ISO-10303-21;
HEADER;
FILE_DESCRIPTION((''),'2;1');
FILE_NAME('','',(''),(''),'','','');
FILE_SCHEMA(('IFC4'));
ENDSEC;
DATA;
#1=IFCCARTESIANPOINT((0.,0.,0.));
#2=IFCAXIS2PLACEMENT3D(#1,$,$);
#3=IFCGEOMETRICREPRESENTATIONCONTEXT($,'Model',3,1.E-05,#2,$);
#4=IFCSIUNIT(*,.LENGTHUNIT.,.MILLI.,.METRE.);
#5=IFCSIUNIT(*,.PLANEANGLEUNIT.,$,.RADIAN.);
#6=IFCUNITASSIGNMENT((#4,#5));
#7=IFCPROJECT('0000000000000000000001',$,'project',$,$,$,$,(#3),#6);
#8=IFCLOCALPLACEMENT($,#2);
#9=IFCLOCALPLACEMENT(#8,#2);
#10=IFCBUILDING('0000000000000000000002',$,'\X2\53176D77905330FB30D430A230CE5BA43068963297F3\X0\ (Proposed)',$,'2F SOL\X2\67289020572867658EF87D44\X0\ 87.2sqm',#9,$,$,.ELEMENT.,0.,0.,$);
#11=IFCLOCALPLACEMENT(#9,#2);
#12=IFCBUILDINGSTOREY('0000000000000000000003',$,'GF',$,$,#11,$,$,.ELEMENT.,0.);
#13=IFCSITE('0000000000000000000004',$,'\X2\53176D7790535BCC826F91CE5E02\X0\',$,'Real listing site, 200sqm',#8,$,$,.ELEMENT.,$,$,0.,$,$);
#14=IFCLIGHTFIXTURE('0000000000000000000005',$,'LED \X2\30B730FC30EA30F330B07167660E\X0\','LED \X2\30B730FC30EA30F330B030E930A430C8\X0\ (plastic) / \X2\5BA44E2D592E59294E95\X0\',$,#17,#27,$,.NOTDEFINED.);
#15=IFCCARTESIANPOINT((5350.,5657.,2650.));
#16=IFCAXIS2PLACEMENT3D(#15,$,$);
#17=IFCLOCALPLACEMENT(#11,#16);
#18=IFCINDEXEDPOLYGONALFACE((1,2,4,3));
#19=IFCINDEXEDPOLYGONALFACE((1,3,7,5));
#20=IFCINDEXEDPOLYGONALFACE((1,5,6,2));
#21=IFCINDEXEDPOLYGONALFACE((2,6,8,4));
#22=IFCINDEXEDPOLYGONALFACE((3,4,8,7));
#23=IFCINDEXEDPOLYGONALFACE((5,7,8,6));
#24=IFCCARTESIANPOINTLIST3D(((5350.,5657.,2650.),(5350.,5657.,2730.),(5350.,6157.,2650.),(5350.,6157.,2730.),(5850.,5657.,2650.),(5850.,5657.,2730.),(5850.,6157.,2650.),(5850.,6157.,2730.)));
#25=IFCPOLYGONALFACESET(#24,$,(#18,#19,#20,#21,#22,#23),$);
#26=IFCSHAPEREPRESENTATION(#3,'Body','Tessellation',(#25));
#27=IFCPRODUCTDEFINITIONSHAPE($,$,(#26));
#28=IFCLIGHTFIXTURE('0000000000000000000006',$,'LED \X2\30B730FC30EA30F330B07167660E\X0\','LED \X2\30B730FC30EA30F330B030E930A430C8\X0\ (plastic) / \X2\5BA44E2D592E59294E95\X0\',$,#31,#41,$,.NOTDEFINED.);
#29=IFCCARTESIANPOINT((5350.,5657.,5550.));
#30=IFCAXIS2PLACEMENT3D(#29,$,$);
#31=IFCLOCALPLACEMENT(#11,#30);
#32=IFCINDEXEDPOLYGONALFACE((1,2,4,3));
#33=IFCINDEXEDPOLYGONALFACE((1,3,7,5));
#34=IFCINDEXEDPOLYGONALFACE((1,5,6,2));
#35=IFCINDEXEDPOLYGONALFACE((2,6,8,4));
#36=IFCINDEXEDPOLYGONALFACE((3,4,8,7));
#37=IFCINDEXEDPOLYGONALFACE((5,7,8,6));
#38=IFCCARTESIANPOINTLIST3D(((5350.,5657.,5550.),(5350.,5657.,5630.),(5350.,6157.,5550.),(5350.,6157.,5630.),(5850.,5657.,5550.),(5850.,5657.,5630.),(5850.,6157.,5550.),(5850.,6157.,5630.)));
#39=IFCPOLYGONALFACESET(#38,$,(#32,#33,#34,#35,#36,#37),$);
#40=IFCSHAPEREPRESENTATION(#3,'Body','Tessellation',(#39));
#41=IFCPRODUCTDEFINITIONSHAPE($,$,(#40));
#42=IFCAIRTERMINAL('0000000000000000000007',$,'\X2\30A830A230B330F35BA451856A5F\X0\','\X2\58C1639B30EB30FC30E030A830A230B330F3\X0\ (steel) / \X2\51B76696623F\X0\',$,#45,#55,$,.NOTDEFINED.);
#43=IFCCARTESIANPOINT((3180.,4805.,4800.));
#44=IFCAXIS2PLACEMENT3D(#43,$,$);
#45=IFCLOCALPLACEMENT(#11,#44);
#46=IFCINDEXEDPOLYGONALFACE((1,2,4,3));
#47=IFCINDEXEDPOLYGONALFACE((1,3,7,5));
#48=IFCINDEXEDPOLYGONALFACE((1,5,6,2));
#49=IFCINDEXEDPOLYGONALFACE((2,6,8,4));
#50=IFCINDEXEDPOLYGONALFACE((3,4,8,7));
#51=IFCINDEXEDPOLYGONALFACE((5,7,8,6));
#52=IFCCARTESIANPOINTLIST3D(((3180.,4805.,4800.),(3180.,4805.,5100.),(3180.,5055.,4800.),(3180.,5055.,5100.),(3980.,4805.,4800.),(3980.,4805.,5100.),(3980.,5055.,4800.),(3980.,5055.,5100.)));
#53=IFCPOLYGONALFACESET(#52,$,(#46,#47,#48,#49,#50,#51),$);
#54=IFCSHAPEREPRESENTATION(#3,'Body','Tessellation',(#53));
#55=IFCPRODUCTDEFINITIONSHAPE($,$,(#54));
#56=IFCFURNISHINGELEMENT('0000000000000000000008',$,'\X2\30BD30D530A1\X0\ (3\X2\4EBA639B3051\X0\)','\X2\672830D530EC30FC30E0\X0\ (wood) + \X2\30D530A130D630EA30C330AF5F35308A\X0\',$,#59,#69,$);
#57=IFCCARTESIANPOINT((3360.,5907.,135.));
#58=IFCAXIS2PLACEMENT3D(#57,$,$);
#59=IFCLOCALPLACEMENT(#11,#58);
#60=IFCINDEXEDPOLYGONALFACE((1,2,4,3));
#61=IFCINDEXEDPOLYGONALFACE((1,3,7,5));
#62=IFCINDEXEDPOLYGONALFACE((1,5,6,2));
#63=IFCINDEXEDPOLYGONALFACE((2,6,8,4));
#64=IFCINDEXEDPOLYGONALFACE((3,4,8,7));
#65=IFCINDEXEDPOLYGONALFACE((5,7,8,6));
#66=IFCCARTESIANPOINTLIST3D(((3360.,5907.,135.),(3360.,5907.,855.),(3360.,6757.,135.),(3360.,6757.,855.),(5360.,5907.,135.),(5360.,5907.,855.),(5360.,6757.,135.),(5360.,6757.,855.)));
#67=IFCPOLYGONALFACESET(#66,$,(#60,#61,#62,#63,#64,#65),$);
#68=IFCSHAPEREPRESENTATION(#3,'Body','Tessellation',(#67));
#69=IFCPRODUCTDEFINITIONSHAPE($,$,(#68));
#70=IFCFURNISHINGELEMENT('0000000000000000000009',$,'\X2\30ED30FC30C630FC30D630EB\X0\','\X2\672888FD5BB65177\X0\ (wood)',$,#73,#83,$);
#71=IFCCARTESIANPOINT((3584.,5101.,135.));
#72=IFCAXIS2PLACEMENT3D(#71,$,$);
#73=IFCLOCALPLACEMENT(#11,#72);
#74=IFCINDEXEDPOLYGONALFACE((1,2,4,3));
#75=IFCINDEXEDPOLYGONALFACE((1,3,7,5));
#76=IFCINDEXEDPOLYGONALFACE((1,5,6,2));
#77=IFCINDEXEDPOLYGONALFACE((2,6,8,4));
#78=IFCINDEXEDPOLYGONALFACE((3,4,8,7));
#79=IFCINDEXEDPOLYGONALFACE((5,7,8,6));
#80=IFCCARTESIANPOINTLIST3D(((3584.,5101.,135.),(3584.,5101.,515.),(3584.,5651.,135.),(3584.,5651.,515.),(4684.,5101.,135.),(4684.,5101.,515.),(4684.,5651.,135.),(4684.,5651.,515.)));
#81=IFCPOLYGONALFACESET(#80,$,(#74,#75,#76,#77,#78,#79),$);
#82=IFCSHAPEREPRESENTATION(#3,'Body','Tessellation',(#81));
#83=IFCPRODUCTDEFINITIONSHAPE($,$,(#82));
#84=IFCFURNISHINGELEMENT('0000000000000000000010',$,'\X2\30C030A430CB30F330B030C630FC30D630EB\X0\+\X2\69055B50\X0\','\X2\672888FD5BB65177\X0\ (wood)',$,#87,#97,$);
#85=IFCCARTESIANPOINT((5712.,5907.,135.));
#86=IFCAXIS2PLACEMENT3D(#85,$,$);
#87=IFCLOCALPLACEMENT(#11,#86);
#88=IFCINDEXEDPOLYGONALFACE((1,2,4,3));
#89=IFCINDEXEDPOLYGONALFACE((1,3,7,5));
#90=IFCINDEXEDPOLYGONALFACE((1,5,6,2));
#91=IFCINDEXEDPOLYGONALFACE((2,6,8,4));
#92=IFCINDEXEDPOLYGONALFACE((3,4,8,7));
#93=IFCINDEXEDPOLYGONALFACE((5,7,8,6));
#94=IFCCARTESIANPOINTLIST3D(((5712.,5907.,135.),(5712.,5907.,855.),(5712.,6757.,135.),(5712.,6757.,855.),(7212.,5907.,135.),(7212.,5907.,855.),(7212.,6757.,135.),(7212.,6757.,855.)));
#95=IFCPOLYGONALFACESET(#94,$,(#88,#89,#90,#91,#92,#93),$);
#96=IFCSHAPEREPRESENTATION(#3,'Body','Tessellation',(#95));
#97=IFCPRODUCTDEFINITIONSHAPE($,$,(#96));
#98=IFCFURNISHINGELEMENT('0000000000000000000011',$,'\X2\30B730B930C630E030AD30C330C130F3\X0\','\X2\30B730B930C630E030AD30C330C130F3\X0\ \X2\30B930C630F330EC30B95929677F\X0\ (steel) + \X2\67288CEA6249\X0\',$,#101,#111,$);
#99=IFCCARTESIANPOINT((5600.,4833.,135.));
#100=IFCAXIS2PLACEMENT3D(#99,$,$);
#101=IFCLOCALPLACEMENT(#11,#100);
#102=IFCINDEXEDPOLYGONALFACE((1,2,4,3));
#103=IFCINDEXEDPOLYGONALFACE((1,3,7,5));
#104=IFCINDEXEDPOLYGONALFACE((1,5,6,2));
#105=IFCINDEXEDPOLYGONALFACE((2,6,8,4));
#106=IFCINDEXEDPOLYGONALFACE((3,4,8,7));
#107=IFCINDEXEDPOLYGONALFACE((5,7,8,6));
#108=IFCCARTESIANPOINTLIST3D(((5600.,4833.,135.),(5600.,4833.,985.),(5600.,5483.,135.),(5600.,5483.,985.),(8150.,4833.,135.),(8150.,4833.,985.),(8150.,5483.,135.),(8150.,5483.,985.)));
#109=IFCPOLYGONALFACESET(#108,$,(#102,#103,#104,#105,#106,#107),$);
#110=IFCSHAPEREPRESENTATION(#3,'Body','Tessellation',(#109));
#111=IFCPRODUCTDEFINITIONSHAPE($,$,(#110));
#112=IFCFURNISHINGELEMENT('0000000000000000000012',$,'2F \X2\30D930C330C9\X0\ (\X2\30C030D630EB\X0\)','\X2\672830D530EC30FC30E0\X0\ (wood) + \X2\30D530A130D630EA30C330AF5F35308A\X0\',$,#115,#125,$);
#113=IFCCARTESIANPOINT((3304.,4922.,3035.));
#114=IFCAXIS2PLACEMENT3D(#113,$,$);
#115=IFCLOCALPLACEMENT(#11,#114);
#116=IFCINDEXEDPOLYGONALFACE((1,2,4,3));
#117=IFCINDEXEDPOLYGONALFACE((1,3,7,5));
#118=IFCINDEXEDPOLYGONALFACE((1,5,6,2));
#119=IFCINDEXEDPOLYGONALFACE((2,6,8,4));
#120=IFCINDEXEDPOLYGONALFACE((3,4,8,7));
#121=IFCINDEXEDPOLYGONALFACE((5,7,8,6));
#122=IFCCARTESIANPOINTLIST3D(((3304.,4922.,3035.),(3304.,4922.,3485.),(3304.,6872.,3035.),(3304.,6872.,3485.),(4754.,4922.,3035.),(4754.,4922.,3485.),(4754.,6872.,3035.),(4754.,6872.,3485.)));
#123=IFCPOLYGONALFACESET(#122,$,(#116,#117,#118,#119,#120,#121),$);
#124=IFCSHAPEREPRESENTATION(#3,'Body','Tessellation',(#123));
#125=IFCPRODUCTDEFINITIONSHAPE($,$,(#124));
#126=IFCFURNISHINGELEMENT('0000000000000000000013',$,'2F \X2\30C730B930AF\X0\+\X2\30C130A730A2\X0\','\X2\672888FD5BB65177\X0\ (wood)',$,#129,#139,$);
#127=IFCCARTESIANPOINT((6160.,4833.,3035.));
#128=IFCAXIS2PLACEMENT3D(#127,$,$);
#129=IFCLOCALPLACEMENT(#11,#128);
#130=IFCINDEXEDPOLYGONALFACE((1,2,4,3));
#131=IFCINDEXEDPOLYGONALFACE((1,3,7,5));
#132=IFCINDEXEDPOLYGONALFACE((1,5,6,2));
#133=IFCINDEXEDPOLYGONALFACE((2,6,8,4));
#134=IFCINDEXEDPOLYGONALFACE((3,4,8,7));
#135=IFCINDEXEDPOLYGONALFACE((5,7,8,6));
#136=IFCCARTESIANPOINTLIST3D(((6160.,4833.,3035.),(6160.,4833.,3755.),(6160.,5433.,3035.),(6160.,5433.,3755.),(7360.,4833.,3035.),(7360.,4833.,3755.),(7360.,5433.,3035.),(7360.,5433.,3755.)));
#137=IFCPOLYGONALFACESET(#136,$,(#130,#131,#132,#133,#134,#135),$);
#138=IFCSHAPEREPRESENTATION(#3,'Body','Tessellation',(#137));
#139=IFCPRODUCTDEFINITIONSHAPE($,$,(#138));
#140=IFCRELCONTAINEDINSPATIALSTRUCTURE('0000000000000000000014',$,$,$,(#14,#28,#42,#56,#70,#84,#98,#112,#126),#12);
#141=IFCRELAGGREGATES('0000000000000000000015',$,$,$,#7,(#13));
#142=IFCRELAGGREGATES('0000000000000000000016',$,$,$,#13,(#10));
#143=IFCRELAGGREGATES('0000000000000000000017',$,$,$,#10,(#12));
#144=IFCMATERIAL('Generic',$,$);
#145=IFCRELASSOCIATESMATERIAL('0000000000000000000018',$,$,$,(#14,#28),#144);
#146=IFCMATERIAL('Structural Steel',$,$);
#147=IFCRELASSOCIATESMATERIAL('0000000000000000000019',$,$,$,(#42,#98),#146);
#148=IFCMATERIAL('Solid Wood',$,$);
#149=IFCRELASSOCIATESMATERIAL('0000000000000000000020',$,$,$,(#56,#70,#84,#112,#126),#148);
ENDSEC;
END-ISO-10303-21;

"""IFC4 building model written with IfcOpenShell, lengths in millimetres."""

from ifc_helpers import new_model, si_unit, frame, frame_2d, origin, place, context, project, spatial, rectangle, extrude, material, element, save


model = new_model("IFC4")

# Units and contexts
model_context = context("Model", 3, precision=1e-05, world=origin())
ifc_project = project(units=[si_unit("LENGTHUNIT", "METRE", prefix="MILLI"), si_unit("PLANEANGLEUNIT", "RADIAN")], contexts=[model_context])

# Site, building, storey
site_placement = place(None, origin())
site = spatial("IfcSite", under=ifc_project, at=site_placement, Name="北海道富良野市", ObjectType="Real listing site, 200sqm", CompositionType="ELEMENT", RefElevation=0.0)
building_placement = place(site_placement, origin())
building = spatial("IfcBuilding", under=site, at=building_placement, Name="北海道・ピアノ室と防音 (Proposed)", ObjectType="2F SOL木造在来軸組 87.2sqm", CompositionType="ELEMENT", ElevationOfRefHeight=0.0, ElevationOfTerrain=0.0)
storey_placement = place(building_placement, origin())
storey = spatial("IfcBuildingStorey", under=building, at=storey_placement, Name="GF", CompositionType="ELEMENT", Elevation=0.0)

# Shared definitions
ifc_material_1 = material(Name="Solid Wood")

# Shared definitions
ifc_material_2 = material(Name="Generic")

# Shared definitions
ifc_material_3 = material(Name="Structural Steel")

# Light fixtures
light_fixture_1_placement = place(storey_placement, frame((5350.0, 5657.0, 2650.0)))
element("IfcLightFixture", 1, at=light_fixture_1_placement, inside=storey, material=ifc_material_2, Name="LED シーリング照明", Description="LED シーリングライト (plastic) / 室中央天井", PredefinedType="NOTDEFINED", context=model_context, shape_type="SweptSolid", body=[
    extrude(rectangle(XDim=500.0, YDim=500.0, at=frame_2d((250.0, 250.0))), frame((5350.0, 5657.0, 2650.0)), (0.0, 0.0, 1.0), 80.0),
])
light_fixture_2_placement = place(storey_placement, frame((5350.0, 5657.0, 5550.0)))
element("IfcLightFixture", 2, at=light_fixture_2_placement, inside=storey, material=ifc_material_2, Name="LED シーリング照明", Description="LED シーリングライト (plastic) / 室中央天井", PredefinedType="NOTDEFINED", context=model_context, shape_type="SweptSolid", body=[
    extrude(rectangle(XDim=500.0, YDim=500.0, at=frame_2d((250.0, 250.0))), frame((5350.0, 5657.0, 5550.0)), (0.0, 0.0, 1.0), 80.0),
])

# Air terminal
air_terminal_placement = place(storey_placement, frame((3180.0, 4805.0, 4800.0)))
element("IfcAirTerminal", 3, at=air_terminal_placement, inside=storey, material=ifc_material_3, Name="エアコン室内機", Description="壁掛ルームエアコン (steel) / 冷暖房", PredefinedType="NOTDEFINED", context=model_context, shape_type="SweptSolid", body=[
    extrude(rectangle(XDim=800.0, YDim=250.0, at=frame_2d((400.0, 125.0))), frame((3180.0, 4805.0, 4800.0)), (0.0, 0.0, 1.0), 300.0),
])

# Furnishing elements
furnishing_1_placement = place(storey_placement, frame((3360.0, 5907.0, 135.0)))
element("IfcFurnishingElement", 4, at=furnishing_1_placement, inside=storey, material=ifc_material_1, Name="ソファ (3人掛け)", Description="木フレーム (wood) + ファブリック張り", context=model_context, shape_type="SweptSolid", body=[
    extrude(rectangle(XDim=2000.0, YDim=850.0, at=frame_2d((1000.0, 425.0))), frame((3360.0, 5907.0, 135.0)), (0.0, 0.0, 1.0), 720.0),
])
furnishing_2_placement = place(storey_placement, frame((3584.0, 5101.0, 135.0)))
element("IfcFurnishingElement", 5, at=furnishing_2_placement, inside=storey, material=ifc_material_1, Name="ローテーブル", Description="木製家具 (wood)", context=model_context, shape_type="SweptSolid", body=[
    extrude(rectangle(XDim=1100.0, YDim=550.0, at=frame_2d((550.0, 275.0))), frame((3584.0, 5101.0, 135.0)), (0.0, 0.0, 1.0), 380.0),
])
furnishing_3_placement = place(storey_placement, frame((5712.0, 5907.0, 135.0)))
element("IfcFurnishingElement", 6, at=furnishing_3_placement, inside=storey, material=ifc_material_1, Name="ダイニングテーブル+椅子", Description="木製家具 (wood)", context=model_context, shape_type="SweptSolid", body=[
    extrude(rectangle(XDim=1500.0, YDim=850.0, at=frame_2d((750.0, 425.0))), frame((5712.0, 5907.0, 135.0)), (0.0, 0.0, 1.0), 720.0),
])
furnishing_4_placement = place(storey_placement, frame((5600.0, 4833.0, 135.0)))
element("IfcFurnishingElement", 7, at=furnishing_4_placement, inside=storey, material=ifc_material_3, Name="システムキッチン", Description="システムキッチン ステンレス天板 (steel) + 木質扉", context=model_context, shape_type="SweptSolid", body=[
    extrude(rectangle(XDim=2550.0, YDim=650.0, at=frame_2d((1275.0, 325.0))), frame((5600.0, 4833.0, 135.0)), (0.0, 0.0, 1.0), 850.0),
])
furnishing_5_placement = place(storey_placement, frame((3304.0, 4922.0, 3035.0)))
element("IfcFurnishingElement", 8, at=furnishing_5_placement, inside=storey, material=ifc_material_1, Name="2F ベッド (ダブル)", Description="木フレーム (wood) + ファブリック張り", context=model_context, shape_type="SweptSolid", body=[
    extrude(rectangle(XDim=1450.0, YDim=1950.0, at=frame_2d((725.0, 975.0))), frame((3304.0, 4922.0, 3035.0)), (0.0, 0.0, 1.0), 450.0),
])
furnishing_6_placement = place(storey_placement, frame((6160.0, 4833.0, 3035.0)))
element("IfcFurnishingElement", 9, at=furnishing_6_placement, inside=storey, material=ifc_material_1, Name="2F デスク+チェア", Description="木製家具 (wood)", context=model_context, shape_type="SweptSolid", body=[
    extrude(rectangle(XDim=1200.0, YDim=600.0, at=frame_2d((600.0, 300.0))), frame((6160.0, 4833.0, 3035.0)), (0.0, 0.0, 1.0), 720.0),
])

save(model, "model.ifc")
